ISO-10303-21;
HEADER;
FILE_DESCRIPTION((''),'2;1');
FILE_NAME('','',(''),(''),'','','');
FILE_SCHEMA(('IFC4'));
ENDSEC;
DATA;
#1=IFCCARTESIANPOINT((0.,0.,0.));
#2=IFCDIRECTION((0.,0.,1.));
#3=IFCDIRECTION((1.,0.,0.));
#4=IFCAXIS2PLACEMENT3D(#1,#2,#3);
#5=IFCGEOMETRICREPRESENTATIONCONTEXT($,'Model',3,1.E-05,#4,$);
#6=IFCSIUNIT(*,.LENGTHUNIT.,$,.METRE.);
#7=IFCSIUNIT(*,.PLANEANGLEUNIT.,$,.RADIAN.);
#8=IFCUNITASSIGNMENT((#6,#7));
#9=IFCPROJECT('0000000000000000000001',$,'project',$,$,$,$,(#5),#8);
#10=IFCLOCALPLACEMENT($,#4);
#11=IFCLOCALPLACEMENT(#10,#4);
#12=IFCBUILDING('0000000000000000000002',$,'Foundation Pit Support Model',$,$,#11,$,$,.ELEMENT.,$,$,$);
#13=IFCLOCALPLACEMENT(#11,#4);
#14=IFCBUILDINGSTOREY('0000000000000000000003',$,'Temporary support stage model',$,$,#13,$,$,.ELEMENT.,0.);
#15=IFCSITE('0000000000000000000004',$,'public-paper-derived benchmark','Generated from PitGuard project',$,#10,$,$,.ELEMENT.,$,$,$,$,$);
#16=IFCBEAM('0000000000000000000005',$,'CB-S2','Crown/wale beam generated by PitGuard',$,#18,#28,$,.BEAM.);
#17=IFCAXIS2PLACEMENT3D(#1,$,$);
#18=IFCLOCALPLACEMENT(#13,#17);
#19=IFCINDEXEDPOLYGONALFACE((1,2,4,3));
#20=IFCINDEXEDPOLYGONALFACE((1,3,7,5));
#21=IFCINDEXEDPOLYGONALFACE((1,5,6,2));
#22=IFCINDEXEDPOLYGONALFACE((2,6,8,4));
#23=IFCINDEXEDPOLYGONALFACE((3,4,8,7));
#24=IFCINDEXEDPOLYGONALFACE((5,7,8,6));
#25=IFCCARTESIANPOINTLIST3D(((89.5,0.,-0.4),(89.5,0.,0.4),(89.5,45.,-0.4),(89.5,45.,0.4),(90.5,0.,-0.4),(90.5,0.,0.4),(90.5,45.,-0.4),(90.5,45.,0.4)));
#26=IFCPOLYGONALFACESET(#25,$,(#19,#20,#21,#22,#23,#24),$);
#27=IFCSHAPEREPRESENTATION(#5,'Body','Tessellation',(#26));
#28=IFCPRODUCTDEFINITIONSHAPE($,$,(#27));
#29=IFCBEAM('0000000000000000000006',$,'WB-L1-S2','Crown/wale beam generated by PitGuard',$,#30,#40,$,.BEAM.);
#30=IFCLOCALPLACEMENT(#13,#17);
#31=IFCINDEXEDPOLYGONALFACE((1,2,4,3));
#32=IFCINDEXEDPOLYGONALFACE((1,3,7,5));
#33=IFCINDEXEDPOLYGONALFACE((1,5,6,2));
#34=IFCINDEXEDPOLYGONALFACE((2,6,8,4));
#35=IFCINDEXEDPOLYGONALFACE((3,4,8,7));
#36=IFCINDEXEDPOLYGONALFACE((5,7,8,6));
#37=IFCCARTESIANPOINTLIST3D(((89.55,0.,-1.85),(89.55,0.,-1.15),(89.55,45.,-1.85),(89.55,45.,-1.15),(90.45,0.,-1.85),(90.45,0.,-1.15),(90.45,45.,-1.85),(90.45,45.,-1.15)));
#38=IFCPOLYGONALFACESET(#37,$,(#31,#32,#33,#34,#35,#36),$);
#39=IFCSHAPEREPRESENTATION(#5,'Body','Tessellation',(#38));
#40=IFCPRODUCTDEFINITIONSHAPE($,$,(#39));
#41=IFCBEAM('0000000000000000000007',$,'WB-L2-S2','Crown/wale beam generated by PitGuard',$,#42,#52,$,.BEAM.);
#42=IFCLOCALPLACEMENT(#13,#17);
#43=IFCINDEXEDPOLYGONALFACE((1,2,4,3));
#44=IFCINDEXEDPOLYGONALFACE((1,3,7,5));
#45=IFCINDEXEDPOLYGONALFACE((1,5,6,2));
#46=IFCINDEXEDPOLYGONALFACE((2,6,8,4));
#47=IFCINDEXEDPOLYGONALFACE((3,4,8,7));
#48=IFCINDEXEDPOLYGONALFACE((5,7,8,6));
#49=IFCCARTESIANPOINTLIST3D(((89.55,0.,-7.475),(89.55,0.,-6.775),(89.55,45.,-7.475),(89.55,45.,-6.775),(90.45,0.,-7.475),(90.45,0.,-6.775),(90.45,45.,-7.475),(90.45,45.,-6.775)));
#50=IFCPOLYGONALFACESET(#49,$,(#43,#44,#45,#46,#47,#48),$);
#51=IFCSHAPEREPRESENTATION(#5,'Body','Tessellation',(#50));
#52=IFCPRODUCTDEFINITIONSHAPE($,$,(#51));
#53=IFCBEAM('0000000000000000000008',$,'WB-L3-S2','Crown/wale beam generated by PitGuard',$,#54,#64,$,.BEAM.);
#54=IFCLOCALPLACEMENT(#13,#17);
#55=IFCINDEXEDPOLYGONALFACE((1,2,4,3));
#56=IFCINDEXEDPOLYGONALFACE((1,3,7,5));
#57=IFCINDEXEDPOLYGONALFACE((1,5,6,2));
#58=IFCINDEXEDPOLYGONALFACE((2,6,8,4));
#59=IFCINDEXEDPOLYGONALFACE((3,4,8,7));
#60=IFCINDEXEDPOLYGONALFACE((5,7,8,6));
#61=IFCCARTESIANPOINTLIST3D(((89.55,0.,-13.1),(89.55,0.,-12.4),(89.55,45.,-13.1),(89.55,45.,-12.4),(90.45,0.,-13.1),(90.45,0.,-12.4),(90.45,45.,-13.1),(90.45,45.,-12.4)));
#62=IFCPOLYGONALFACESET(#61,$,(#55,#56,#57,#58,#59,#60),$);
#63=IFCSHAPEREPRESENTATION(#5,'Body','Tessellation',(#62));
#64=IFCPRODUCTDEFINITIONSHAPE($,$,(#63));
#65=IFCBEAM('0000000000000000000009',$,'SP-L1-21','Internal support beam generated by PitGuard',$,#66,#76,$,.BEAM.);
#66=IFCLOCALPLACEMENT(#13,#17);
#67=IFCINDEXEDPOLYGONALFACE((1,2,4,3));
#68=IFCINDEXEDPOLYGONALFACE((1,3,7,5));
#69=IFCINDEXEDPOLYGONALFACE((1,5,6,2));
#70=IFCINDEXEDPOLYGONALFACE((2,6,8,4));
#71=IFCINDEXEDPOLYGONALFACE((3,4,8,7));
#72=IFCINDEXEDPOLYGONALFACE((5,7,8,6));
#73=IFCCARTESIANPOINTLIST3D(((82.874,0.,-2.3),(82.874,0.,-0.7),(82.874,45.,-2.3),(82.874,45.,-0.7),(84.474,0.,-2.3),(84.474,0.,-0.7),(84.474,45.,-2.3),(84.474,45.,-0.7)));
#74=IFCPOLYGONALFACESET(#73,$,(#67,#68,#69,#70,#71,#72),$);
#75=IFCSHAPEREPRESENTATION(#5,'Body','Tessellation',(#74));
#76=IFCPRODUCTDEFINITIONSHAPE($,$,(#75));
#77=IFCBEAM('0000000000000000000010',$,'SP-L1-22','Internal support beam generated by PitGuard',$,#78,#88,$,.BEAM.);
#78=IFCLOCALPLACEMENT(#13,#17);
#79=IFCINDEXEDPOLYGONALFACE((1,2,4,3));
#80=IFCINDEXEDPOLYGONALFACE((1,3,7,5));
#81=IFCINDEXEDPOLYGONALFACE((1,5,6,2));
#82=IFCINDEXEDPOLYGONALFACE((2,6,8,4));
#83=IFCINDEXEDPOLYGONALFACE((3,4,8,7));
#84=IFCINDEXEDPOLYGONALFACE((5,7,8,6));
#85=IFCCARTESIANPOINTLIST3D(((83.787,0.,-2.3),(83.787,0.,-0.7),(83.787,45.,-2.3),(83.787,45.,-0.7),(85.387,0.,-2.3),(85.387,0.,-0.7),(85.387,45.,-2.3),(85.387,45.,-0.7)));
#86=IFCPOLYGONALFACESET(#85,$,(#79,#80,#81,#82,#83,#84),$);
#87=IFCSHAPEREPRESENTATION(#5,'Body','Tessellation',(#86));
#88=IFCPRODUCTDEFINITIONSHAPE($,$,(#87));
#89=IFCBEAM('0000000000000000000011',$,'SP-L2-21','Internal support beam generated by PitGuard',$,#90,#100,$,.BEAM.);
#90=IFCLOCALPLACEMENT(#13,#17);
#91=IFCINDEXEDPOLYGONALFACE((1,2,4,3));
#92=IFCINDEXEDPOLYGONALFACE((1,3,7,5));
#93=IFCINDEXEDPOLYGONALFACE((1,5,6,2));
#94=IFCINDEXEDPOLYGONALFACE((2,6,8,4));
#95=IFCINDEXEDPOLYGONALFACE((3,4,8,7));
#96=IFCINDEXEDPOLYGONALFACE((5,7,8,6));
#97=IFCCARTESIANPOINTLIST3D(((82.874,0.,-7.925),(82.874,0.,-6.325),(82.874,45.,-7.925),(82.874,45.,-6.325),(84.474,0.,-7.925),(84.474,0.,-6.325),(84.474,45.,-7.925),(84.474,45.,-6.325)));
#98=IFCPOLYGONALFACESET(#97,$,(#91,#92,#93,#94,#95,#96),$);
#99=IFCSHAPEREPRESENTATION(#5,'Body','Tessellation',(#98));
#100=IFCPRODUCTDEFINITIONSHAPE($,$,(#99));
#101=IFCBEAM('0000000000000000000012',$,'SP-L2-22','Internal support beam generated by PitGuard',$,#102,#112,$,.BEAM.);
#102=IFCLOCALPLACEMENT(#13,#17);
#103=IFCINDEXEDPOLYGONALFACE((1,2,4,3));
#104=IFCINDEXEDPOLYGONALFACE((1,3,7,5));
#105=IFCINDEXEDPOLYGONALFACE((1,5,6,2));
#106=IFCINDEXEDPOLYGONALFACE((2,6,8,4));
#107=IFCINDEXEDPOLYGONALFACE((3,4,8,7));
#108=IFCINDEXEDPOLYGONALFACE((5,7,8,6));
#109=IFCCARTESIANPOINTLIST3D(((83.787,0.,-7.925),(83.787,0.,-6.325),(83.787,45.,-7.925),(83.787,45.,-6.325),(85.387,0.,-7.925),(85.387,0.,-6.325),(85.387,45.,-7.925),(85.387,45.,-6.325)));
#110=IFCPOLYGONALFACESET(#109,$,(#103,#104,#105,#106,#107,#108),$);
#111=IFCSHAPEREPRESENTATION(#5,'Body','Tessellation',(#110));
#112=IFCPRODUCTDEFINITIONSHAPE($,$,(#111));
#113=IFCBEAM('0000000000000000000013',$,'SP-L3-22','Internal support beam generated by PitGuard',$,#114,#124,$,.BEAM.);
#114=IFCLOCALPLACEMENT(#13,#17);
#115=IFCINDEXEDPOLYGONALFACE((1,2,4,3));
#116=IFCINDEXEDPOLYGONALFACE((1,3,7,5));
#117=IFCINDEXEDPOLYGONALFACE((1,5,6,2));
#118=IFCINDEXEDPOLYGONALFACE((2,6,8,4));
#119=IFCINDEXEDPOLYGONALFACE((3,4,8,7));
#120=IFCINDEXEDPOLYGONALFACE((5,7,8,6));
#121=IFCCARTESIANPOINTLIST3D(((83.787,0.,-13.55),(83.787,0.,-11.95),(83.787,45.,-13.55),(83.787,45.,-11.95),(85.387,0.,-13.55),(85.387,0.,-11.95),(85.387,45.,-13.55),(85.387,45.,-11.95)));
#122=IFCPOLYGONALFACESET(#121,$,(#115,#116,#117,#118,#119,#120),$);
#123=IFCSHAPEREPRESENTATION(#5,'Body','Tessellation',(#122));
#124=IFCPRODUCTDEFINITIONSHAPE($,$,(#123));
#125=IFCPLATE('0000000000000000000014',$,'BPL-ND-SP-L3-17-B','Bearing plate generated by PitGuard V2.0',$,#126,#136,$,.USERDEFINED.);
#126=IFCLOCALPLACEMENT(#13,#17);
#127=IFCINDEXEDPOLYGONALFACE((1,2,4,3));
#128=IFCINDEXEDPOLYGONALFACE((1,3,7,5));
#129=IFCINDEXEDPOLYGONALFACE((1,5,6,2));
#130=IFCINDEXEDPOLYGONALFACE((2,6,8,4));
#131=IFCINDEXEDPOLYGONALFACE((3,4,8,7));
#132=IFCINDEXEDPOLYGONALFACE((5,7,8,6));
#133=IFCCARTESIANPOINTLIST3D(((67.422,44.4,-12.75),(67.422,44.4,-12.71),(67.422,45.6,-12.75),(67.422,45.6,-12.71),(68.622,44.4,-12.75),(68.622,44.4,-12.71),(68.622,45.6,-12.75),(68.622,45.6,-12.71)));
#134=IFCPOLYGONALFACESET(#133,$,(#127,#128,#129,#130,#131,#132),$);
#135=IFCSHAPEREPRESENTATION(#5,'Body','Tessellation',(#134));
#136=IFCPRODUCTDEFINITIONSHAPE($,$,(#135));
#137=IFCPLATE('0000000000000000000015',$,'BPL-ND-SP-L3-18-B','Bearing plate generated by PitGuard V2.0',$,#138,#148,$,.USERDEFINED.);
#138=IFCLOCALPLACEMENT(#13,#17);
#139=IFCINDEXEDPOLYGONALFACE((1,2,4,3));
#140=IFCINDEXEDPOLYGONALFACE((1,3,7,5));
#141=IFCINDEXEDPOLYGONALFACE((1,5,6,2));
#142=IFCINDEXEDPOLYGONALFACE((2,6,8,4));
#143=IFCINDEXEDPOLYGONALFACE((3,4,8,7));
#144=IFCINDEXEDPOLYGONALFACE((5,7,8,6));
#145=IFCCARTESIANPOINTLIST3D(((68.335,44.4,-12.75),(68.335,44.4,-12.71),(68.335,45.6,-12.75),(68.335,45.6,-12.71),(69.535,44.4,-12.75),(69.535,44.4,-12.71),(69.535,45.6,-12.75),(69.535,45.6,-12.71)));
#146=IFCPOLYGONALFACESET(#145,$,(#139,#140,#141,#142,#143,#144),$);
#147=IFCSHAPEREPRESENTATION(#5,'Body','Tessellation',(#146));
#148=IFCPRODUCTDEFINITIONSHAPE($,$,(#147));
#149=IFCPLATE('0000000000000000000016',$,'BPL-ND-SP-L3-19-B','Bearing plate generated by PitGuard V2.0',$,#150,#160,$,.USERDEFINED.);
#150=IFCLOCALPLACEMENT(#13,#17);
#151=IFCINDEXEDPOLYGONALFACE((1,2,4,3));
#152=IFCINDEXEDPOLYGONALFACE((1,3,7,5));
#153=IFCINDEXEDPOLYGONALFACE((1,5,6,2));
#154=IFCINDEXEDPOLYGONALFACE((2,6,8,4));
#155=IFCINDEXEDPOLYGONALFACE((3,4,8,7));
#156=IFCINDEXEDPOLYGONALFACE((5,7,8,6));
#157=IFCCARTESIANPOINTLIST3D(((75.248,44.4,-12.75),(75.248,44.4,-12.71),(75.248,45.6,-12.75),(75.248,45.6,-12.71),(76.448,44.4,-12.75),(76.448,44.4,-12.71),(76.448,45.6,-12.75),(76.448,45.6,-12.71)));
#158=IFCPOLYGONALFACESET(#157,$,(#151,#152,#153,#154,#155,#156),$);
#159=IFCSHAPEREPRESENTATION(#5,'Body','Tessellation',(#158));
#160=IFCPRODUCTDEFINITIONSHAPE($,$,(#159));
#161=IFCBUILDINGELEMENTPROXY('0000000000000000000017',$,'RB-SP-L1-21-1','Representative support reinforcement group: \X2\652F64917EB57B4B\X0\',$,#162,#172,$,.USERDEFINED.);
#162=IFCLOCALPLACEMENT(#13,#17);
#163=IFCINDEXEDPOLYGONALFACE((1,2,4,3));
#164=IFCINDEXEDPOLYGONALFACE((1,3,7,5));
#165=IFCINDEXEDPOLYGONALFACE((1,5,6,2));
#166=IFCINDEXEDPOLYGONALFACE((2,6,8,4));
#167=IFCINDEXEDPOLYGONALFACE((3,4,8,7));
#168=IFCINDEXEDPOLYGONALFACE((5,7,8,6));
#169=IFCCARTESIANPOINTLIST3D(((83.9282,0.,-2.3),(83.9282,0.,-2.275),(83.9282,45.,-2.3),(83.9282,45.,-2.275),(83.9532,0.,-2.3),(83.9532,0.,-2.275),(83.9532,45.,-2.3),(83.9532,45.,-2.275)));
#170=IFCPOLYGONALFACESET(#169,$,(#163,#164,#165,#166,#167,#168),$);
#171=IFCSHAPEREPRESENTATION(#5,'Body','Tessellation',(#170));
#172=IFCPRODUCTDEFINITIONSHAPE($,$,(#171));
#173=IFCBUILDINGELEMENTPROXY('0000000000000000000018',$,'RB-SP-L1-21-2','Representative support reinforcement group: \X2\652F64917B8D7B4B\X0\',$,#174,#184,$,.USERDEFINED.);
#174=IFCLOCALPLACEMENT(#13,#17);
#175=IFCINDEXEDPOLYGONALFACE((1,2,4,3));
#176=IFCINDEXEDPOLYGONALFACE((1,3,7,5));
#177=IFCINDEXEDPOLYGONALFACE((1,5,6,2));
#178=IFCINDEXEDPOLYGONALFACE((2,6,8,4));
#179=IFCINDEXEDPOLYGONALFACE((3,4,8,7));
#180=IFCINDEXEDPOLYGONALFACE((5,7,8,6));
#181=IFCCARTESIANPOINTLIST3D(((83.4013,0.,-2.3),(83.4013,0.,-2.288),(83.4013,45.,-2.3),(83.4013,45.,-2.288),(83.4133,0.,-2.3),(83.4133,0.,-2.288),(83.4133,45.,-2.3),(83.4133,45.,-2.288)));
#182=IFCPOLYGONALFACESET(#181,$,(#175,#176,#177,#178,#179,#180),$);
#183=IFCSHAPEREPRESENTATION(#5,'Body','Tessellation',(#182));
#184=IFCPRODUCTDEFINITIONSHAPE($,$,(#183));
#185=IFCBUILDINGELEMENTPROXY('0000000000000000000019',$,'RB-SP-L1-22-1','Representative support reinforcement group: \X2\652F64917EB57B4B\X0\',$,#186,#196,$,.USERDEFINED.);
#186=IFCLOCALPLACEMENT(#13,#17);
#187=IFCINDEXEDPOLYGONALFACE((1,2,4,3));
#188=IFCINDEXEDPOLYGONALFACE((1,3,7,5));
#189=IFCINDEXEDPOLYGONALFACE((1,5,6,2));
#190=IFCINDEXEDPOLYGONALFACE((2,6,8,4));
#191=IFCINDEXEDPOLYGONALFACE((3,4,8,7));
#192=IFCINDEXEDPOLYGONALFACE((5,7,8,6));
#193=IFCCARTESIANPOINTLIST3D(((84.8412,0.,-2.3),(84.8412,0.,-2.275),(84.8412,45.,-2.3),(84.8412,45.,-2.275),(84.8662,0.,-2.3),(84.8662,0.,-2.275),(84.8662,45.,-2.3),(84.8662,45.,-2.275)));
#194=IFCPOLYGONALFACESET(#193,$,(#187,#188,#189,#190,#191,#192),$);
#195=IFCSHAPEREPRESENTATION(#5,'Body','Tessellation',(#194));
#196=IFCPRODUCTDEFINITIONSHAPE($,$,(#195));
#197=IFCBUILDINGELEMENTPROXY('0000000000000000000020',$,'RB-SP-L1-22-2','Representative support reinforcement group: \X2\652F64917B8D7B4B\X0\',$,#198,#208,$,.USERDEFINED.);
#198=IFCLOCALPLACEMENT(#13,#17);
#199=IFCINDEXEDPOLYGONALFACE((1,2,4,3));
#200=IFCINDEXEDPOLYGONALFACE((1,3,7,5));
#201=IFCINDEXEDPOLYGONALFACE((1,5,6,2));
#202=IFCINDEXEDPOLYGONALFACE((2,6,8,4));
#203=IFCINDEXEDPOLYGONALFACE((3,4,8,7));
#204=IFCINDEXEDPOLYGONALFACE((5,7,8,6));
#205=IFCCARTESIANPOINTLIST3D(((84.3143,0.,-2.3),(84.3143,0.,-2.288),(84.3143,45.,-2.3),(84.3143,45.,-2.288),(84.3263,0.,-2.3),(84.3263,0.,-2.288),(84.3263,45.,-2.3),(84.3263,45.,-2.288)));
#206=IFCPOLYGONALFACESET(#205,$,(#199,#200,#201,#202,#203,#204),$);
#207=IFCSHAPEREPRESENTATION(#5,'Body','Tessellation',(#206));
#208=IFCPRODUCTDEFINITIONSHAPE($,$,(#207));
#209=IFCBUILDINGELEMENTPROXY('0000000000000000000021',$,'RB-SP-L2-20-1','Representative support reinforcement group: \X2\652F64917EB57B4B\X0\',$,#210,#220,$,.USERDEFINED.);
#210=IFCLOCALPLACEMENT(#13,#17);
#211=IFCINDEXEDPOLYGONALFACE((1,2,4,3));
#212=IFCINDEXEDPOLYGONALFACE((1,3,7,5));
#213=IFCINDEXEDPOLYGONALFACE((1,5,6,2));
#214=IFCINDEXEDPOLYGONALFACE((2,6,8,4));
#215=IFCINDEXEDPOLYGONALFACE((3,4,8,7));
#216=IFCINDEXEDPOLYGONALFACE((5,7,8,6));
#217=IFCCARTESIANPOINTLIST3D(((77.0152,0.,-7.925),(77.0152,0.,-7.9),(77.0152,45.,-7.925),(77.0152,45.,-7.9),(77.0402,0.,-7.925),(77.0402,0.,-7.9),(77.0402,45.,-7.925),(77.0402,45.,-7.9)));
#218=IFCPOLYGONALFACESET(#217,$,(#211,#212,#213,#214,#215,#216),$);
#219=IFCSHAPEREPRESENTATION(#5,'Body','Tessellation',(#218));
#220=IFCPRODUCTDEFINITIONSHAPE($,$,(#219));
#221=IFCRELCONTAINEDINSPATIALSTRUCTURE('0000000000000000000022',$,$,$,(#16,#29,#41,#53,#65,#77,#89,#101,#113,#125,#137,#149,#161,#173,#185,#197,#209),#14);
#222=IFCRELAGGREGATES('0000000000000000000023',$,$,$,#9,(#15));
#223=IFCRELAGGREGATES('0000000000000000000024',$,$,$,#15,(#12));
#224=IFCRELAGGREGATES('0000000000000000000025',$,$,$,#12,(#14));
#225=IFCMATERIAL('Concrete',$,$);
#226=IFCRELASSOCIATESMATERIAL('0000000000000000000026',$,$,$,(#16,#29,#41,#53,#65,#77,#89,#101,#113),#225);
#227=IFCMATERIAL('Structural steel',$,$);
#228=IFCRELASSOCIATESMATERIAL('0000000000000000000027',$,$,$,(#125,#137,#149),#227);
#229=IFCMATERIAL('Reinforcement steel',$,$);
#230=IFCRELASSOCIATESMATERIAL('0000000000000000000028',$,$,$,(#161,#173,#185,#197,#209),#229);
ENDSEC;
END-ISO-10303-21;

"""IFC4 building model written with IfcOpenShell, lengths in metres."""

from ifc_helpers import new_model, si_unit, frame, origin_with_axes, origin_2d, place, context, project, spatial, rectangle, extrude, material, element, save


model = new_model("IFC4")

# Units and contexts
model_context = context("Model", 3, precision=1e-05, world=origin_with_axes())
ifc_project = project(units=[si_unit("LENGTHUNIT", "METRE"), si_unit("PLANEANGLEUNIT", "RADIAN")], contexts=[model_context])

# Site, building, storey
site_placement = place(None, origin_with_axes())
site = spatial("IfcSite", under=ifc_project, at=site_placement, Name="public-paper-derived benchmark", Description="Generated from PitGuard project", CompositionType="ELEMENT")
building_placement = place(site_placement, origin_with_axes())
building = spatial("IfcBuilding", under=site, at=building_placement, Name="Foundation Pit Support Model", CompositionType="ELEMENT")
storey_placement = place(building_placement, origin_with_axes())
storey = spatial("IfcBuildingStorey", under=building, at=storey_placement, Name="Temporary support stage model", CompositionType="ELEMENT", Elevation=0.0)

# Beams
ifc_material_1 = material(Name="Concrete")
beam_placement = place(storey_placement, frame((90.0, 22.5, -0.4), z_axis=(0.0, 0.0, 1.0), x_axis=(0.0, 1.0, 0.0)))
element("IfcBeam", 1, at=beam_placement, inside=storey, material=ifc_material_1, Name="CB-S2", Description="Crown/wale beam generated by PitGuard", PredefinedType="BEAM", context=model_context, shape_type="SweptSolid", body=[
    extrude(rectangle(XDim=45.0, YDim=1.0, at=origin_2d()), origin_with_axes(), (0.0, 0.0, 1.0), 0.8),
])
for number, where, z_axis, x_axis, name in (
    (2, (90.0, 22.5, -1.85), (0.0, 0.0, 1.0), (0.0, 1.0, 0.0), "WB-L1-S2"),
    (3, (90.0, 22.5, -7.475), (0.0, 0.0, 1.0), (0.0, 1.0, 0.0), "WB-L2-S2"),
    (4, (90.0, 22.5, -13.1), (0.0, 0.0, 1.0), (0.0, 1.0, 0.0), "WB-L3-S2"),
):
    element("IfcBeam", number, at=place(storey_placement, frame(where, z_axis=z_axis, x_axis=x_axis)), inside=storey, material=ifc_material_1, Name=name, Description="Crown/wale beam generated by PitGuard", PredefinedType="BEAM", context=model_context, shape_type="SweptSolid", body=[
        extrude(rectangle(XDim=45.0, YDim=0.9, at=origin_2d()), origin_with_axes(), (0.0, 0.0, 1.0), 0.7),
    ])
for number, where, z_axis, x_axis, name in (
    (5, (83.674, 22.5, -2.3), (0.0, 0.0, 1.0), (0.0, 1.0, 0.0), "SP-L1-21"),
    (6, (84.587, 22.5, -2.3), (0.0, 0.0, 1.0), (0.0, 1.0, 0.0), "SP-L1-22"),
    (7, (83.674, 22.5, -7.925), (0.0, 0.0, 1.0), (0.0, 1.0, 0.0), "SP-L2-21"),
    (8, (84.587, 22.5, -7.925), (0.0, 0.0, 1.0), (0.0, 1.0, 0.0), "SP-L2-22"),
    (9, (84.587, 22.5, -13.55), (0.0, 0.0, 1.0), (0.0, 1.0, 0.0), "SP-L3-22"),
):
    element("IfcBeam", number, at=place(storey_placement, frame(where, z_axis=z_axis, x_axis=x_axis)), inside=storey, material=ifc_material_1, Name=name, Description="Internal support beam generated by PitGuard", PredefinedType="BEAM", context=model_context, shape_type="SweptSolid", body=[
        extrude(rectangle(XDim=45.0, YDim=1.6, at=origin_2d()), origin_with_axes(), (0.0, 0.0, 1.0), 1.6),
    ])

# Plates
ifc_material_2 = material(Name="Structural steel")
for number, where, z_axis, x_axis, name in (
    (10, (68.022, 45.0, -12.75), (0.0, 0.0, 1.0), (1.0, 0.0, 0.0), "BPL-ND-SP-L3-17-B"),
    (11, (68.935, 45.0, -12.75), (0.0, 0.0, 1.0), (1.0, 0.0, 0.0), "BPL-ND-SP-L3-18-B"),
    (12, (75.848, 45.0, -12.75), (0.0, 0.0, 1.0), (1.0, 0.0, 0.0), "BPL-ND-SP-L3-19-B"),
):
    element("IfcPlate", number, at=place(storey_placement, frame(where, z_axis=z_axis, x_axis=x_axis)), inside=storey, material=ifc_material_2, Name=name, Description="Bearing plate generated by PitGuard V2.0", PredefinedType="USERDEFINED", context=model_context, shape_type="SweptSolid", body=[
        extrude(rectangle(XDim=1.2, YDim=1.2, at=origin_2d()), origin_with_axes(), (0.0, 0.0, 1.0), 0.04),
    ])

# Building element proxies
ifc_material_3 = material(Name="Reinforcement steel")
proxy_1_placement = place(storey_placement, frame((83.9407, 22.5, -2.3), z_axis=(0.0, 0.0, 1.0), x_axis=(0.0, 1.0, 0.0)))
element("IfcBuildingElementProxy", 13, at=proxy_1_placement, inside=storey, material=ifc_material_3, Name="RB-SP-L1-21-1", Description="Representative support reinforcement group: 支撑纵筋", PredefinedType="USERDEFINED", context=model_context, shape_type="SweptSolid", body=[
    extrude(rectangle(XDim=45.0, YDim=0.025, at=origin_2d()), origin_with_axes(), (0.0, 0.0, 1.0), 0.025),
])
proxy_2_placement = place(storey_placement, frame((83.4073, 22.5, -2.3), z_axis=(0.0, 0.0, 1.0), x_axis=(0.0, 1.0, 0.0)))
element("IfcBuildingElementProxy", 14, at=proxy_2_placement, inside=storey, material=ifc_material_3, Name="RB-SP-L1-21-2", Description="Representative support reinforcement group: 支撑箍筋", PredefinedType="USERDEFINED", context=model_context, shape_type="SweptSolid", body=[
    extrude(rectangle(XDim=45.0, YDim=0.012, at=origin_2d()), origin_with_axes(), (0.0, 0.0, 1.0), 0.012),
])
proxy_3_placement = place(storey_placement, frame((84.8537, 22.5, -2.3), z_axis=(0.0, 0.0, 1.0), x_axis=(0.0, 1.0, 0.0)))
element("IfcBuildingElementProxy", 15, at=proxy_3_placement, inside=storey, material=ifc_material_3, Name="RB-SP-L1-22-1", Description="Representative support reinforcement group: 支撑纵筋", PredefinedType="USERDEFINED", context=model_context, shape_type="SweptSolid", body=[
    extrude(rectangle(XDim=45.0, YDim=0.025, at=origin_2d()), origin_with_axes(), (0.0, 0.0, 1.0), 0.025),
])
proxy_4_placement = place(storey_placement, frame((84.3203, 22.5, -2.3), z_axis=(0.0, 0.0, 1.0), x_axis=(0.0, 1.0, 0.0)))
element("IfcBuildingElementProxy", 16, at=proxy_4_placement, inside=storey, material=ifc_material_3, Name="RB-SP-L1-22-2", Description="Representative support reinforcement group: 支撑箍筋", PredefinedType="USERDEFINED", context=model_context, shape_type="SweptSolid", body=[
    extrude(rectangle(XDim=45.0, YDim=0.012, at=origin_2d()), origin_with_axes(), (0.0, 0.0, 1.0), 0.012),
])
for number, where, z_axis, x_axis, name in (
    (17, (77.0277, 22.5, -7.925), (0.0, 0.0, 1.0), (0.0, 1.0, 0.0), "RB-SP-L2-20-1"),
):
    element("IfcBuildingElementProxy", number, at=place(storey_placement, frame(where, z_axis=z_axis, x_axis=x_axis)), inside=storey, material=ifc_material_3, Name=name, Description="Representative support reinforcement group: 支撑纵筋", PredefinedType="USERDEFINED", context=model_context, shape_type="SweptSolid", body=[
        extrude(rectangle(XDim=45.0, YDim=0.025, at=origin_2d()), origin_with_axes(), (0.0, 0.0, 1.0), 0.025),
    ])

save(model, "model.ifc")
